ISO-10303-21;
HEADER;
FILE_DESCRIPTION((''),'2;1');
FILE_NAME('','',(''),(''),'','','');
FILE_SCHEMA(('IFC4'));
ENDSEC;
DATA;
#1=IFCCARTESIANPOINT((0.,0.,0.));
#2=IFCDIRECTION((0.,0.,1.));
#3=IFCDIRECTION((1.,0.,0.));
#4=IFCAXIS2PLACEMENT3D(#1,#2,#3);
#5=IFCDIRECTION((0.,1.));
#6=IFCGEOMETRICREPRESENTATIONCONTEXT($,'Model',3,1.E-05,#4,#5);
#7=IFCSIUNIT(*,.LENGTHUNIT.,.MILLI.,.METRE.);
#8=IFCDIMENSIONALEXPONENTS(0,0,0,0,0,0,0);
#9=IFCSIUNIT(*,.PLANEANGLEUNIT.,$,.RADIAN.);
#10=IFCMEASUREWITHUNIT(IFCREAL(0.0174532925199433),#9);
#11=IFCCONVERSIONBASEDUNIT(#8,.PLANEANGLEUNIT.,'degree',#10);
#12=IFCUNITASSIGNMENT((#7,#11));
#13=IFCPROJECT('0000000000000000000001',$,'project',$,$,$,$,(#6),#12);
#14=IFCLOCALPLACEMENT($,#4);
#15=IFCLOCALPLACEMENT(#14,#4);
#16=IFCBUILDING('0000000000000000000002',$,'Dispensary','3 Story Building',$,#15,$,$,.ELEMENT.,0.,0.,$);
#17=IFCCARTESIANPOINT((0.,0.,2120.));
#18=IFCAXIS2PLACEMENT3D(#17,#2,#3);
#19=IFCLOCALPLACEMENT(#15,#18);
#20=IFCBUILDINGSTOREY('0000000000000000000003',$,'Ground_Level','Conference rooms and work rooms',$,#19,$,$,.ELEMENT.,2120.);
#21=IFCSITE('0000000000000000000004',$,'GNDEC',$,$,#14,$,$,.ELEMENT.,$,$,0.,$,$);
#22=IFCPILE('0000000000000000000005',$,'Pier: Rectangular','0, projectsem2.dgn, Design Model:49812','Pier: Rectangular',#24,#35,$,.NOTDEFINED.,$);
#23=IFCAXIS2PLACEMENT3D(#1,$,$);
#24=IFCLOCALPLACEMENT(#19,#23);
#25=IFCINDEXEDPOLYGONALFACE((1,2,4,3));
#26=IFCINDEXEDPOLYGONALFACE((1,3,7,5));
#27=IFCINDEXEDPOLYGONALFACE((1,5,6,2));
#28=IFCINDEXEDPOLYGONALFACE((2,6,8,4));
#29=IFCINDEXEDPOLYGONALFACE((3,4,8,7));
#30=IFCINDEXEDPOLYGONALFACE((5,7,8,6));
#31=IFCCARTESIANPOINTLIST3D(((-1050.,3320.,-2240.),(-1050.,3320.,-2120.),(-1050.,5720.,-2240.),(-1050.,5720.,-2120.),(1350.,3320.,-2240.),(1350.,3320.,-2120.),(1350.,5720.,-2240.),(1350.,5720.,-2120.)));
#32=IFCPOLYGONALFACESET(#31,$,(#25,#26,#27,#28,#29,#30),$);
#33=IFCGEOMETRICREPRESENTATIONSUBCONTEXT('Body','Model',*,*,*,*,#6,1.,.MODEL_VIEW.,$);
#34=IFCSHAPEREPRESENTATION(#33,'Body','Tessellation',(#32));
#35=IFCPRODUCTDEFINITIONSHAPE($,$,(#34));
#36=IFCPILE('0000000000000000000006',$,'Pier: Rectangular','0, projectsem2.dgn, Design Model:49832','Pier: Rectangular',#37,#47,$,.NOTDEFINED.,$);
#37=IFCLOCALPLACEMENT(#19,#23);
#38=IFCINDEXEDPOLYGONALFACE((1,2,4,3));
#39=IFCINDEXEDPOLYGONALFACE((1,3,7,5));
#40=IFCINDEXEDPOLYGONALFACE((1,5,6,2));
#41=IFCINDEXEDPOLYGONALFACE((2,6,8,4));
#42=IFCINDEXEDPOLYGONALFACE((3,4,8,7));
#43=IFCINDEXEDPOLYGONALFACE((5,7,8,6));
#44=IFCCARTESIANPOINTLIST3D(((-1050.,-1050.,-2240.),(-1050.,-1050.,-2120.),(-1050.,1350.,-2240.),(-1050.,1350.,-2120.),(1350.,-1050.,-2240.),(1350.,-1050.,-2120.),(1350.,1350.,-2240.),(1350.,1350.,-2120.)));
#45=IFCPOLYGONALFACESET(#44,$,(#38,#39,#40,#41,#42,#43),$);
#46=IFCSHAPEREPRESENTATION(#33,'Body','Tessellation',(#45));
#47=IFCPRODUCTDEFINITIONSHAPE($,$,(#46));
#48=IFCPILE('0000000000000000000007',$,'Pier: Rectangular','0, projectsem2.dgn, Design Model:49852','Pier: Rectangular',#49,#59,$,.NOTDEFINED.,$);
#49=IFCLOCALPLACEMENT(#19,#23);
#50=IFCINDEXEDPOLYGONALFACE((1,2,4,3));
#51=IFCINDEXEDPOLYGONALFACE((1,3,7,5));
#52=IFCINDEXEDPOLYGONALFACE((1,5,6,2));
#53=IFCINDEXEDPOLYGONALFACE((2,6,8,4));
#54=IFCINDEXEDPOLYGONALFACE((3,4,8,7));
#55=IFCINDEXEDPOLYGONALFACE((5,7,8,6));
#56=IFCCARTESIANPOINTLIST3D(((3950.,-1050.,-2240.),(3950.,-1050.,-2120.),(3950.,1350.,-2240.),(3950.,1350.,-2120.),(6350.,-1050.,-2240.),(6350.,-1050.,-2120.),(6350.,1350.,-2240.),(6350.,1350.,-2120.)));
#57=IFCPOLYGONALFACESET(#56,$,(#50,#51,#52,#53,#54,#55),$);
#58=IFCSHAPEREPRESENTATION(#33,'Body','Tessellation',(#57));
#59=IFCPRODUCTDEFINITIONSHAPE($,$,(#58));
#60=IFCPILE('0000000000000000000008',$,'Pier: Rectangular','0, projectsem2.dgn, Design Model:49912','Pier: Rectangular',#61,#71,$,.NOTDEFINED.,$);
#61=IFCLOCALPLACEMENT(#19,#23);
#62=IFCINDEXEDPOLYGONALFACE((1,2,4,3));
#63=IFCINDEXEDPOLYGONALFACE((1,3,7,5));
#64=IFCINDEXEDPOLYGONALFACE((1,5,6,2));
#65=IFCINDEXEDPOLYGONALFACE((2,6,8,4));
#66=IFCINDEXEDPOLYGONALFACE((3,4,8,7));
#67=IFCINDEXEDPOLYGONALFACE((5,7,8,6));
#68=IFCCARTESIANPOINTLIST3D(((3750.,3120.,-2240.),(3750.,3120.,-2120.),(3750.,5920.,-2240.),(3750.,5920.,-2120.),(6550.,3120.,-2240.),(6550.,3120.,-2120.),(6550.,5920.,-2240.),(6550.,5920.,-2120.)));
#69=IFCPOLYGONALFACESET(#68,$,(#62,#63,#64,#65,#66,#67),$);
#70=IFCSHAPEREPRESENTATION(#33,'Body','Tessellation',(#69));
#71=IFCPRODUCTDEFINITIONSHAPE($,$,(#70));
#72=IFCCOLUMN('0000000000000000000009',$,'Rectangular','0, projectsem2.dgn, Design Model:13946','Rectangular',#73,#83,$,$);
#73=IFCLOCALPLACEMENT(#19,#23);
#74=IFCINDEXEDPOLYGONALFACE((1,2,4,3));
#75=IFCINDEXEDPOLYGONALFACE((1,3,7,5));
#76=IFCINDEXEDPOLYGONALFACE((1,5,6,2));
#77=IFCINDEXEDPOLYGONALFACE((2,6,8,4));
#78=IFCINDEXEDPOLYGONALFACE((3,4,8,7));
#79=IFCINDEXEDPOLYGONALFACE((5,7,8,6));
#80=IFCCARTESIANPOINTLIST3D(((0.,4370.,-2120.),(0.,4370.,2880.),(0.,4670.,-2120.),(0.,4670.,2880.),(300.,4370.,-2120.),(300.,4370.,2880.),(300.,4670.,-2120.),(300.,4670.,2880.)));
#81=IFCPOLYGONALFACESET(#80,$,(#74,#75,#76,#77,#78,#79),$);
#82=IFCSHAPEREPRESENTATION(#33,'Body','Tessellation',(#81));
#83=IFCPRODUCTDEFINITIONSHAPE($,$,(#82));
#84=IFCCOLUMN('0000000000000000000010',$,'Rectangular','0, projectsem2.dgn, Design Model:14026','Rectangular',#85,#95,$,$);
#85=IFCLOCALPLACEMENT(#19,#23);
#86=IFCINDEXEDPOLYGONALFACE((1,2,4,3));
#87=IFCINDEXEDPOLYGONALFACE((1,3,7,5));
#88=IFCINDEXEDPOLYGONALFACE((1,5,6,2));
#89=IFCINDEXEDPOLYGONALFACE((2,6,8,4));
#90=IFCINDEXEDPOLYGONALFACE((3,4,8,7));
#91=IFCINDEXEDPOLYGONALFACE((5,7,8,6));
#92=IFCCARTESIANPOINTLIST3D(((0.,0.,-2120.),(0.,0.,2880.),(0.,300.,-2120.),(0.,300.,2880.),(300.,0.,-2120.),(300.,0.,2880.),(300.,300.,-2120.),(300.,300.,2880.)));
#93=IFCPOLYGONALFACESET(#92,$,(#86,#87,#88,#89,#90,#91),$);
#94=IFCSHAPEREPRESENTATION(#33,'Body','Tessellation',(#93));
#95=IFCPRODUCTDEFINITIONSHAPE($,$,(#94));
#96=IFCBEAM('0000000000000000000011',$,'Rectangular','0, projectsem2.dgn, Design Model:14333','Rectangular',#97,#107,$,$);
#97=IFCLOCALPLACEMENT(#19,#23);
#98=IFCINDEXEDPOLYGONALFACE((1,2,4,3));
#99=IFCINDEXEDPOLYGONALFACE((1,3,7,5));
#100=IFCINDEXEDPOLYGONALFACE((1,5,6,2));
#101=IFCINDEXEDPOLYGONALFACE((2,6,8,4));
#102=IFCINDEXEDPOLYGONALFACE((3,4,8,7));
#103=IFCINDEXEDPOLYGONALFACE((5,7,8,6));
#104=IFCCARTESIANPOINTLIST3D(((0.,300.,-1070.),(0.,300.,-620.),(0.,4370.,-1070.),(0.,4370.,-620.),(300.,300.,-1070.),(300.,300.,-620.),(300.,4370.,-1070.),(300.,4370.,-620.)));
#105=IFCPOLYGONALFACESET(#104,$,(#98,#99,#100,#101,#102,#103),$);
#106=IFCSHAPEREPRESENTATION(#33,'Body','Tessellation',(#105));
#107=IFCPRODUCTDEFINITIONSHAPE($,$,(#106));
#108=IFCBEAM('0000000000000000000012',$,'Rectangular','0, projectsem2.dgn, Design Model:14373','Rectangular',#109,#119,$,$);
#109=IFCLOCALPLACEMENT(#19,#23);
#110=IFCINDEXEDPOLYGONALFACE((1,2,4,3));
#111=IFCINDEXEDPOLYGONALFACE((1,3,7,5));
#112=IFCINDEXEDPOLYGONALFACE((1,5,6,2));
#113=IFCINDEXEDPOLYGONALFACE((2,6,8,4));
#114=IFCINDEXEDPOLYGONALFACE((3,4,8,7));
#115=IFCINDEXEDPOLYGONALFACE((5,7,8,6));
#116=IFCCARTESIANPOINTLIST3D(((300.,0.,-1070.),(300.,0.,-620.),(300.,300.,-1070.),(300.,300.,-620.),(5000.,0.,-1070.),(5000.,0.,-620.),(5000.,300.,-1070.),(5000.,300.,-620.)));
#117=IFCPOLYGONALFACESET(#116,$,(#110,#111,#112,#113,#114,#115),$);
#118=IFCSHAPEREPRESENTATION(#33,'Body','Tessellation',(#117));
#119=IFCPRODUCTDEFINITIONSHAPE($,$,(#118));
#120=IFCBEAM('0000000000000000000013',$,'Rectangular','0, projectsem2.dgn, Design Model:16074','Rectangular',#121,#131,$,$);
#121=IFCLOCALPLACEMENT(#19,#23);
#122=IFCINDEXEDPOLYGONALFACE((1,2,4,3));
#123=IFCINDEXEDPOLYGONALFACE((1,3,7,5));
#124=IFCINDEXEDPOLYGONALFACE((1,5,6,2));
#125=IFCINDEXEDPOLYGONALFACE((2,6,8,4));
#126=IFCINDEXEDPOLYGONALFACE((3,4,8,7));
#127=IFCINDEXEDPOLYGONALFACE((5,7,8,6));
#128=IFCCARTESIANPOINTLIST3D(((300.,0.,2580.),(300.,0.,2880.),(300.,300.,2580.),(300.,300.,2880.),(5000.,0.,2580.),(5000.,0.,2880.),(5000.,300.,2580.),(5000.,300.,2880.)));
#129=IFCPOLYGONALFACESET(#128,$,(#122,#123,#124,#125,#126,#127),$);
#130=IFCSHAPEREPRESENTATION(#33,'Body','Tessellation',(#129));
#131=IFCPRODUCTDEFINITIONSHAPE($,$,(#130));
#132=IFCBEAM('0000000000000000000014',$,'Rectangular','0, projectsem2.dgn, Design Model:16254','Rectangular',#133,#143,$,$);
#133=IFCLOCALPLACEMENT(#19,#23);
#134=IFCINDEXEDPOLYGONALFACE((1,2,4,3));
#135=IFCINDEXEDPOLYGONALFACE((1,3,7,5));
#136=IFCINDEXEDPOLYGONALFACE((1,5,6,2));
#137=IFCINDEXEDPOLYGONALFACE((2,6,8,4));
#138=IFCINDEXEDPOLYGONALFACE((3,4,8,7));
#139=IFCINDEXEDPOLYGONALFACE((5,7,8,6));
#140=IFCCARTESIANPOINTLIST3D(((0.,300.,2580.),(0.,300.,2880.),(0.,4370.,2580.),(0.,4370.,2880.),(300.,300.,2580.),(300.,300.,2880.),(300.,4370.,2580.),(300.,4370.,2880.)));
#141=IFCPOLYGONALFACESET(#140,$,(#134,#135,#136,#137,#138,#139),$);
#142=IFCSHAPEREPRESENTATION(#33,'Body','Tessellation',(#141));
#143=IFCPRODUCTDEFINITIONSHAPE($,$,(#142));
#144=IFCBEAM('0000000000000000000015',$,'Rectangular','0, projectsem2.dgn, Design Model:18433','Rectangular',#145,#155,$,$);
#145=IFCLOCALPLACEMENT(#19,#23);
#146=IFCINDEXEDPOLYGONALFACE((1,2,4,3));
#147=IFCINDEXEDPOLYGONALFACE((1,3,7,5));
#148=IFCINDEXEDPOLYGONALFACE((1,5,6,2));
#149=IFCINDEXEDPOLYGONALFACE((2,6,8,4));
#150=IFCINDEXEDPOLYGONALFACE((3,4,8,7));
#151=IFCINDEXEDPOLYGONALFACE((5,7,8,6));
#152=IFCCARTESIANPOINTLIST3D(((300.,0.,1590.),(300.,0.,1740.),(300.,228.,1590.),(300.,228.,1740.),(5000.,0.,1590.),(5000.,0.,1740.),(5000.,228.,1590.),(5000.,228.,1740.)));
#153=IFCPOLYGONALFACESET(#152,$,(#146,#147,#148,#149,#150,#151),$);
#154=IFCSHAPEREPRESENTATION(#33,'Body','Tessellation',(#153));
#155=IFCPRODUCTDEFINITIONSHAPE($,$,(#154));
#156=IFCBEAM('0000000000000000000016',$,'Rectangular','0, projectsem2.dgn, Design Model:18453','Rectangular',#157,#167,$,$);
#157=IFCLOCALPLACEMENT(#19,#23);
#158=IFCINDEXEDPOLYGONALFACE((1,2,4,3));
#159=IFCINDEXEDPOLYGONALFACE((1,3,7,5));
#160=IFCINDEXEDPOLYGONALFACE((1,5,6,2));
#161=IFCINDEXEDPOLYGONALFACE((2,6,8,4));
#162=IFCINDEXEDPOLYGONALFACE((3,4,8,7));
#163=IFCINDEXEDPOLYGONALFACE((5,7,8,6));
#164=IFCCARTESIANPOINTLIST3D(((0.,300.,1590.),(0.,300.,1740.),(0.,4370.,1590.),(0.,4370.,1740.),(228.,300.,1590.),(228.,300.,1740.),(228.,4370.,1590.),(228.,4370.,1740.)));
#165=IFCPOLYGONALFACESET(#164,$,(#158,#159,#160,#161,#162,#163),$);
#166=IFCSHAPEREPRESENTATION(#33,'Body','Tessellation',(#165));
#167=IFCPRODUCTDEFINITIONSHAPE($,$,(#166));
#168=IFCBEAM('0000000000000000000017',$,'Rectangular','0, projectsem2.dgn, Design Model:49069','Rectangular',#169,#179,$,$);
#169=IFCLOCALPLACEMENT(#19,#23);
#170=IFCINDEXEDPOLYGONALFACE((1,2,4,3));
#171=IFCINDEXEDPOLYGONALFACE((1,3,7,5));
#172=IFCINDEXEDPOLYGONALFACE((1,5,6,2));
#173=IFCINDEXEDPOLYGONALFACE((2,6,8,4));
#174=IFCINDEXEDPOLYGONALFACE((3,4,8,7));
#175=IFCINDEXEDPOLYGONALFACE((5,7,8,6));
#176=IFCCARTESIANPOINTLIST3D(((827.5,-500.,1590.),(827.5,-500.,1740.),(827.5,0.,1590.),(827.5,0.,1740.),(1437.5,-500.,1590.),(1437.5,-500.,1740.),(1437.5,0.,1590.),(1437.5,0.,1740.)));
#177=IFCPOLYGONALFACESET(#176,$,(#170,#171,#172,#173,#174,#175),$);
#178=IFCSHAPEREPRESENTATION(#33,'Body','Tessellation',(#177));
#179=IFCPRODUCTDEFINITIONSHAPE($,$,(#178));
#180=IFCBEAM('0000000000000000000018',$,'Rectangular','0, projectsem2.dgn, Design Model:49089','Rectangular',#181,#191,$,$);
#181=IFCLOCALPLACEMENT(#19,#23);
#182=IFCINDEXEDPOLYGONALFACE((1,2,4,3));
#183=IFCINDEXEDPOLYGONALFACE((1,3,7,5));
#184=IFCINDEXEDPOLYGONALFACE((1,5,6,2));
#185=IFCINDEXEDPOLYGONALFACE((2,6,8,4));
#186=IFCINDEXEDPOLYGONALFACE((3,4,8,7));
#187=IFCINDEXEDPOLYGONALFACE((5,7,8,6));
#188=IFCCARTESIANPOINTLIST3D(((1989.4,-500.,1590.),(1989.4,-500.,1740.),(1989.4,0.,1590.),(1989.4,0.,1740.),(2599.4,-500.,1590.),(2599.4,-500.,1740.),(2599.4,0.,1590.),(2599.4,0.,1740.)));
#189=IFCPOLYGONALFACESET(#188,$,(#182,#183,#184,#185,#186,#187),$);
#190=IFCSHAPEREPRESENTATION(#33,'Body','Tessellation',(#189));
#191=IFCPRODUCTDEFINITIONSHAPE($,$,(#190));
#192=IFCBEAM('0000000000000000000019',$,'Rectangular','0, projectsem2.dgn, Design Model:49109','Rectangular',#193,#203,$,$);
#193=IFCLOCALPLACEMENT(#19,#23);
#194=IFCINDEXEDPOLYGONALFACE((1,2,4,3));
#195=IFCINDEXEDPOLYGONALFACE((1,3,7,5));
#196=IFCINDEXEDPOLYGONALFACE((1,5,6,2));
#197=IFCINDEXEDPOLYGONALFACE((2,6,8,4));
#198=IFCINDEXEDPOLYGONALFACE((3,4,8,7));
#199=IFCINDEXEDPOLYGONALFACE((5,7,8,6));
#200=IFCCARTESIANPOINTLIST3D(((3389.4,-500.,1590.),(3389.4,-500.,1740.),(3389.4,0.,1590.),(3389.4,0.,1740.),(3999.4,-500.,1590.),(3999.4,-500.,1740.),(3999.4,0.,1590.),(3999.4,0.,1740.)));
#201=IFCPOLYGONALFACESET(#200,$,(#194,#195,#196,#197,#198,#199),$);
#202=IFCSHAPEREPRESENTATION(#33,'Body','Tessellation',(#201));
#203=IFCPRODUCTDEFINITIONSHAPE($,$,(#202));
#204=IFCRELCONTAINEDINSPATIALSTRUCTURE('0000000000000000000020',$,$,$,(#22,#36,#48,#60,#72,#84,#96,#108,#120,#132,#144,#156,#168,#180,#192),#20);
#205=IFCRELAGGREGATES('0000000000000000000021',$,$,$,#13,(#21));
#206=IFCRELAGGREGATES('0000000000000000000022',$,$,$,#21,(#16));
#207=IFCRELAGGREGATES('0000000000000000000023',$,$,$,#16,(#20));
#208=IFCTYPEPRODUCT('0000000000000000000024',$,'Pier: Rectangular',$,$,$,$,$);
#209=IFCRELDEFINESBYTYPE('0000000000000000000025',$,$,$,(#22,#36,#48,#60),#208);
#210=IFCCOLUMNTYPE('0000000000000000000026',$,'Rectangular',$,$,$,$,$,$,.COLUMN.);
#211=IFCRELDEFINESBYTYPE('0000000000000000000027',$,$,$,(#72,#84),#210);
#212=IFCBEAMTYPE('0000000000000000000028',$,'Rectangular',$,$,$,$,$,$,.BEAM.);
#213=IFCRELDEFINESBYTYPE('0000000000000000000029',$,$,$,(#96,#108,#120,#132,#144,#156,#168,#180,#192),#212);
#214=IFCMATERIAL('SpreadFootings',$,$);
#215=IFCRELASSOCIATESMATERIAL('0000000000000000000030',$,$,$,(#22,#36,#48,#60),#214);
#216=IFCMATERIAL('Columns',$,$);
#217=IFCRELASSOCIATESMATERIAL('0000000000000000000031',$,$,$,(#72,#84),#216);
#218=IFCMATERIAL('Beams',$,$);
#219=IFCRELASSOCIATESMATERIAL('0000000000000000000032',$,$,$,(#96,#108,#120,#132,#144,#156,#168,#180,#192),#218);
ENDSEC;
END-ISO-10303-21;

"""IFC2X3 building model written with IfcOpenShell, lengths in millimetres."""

from ifc_helpers import new_model, entity, si_unit, converted_unit, direction, frame, frame_2d, origin_with_axes, place, context, subcontext, project, spatial, rectangle, extrude, material, type_object, element, save


model = new_model("IFC2X3")

# Units and contexts
model_context = context("Model", 3, precision=1e-05, world=origin_with_axes(), true_north=direction((0.0, 1.0)))
body_context = subcontext(model_context, "Body", "Model", "MODEL_VIEW", scale=1.0)
ifc_project = project(units=[si_unit("LENGTHUNIT", "METRE", prefix="MILLI"), converted_unit("PLANEANGLEUNIT", "degree", entity("IfcReal", 0.0174532925199433), si_unit("PLANEANGLEUNIT", "RADIAN"), dimensions=[0, 0, 0, 0, 0, 0, 0])], contexts=[model_context])

# Site, building, storey
site_placement = place(None, origin_with_axes())
site = spatial("IfcSite", under=ifc_project, at=site_placement, Name="GNDEC", CompositionType="ELEMENT", RefElevation=0.0)
building_placement = place(site_placement, origin_with_axes())
building = spatial("IfcBuilding", under=site, at=building_placement, Name="Dispensary", Description="3 Story Building", CompositionType="ELEMENT", ElevationOfRefHeight=0.0, ElevationOfTerrain=0.0)
storey_placement = place(building_placement, frame((0.0, 0.0, 2120.0), z_axis=(0.0, 0.0, 1.0), x_axis=(1.0, 0.0, 0.0)))
storey = spatial("IfcBuildingStorey", under=building, at=storey_placement, Name="Ground_Level", Description="Conference rooms and work rooms", CompositionType="ELEMENT", Elevation=2120.0)

# Piles
ifc_material_1 = material(Name="SpreadFootings")
type_product = type_object("IfcTypeProduct", Name="Pier: Rectangular")
for number, where, z_axis, x_axis, name, description in (
    (1, (-1050.0, 5720.0, -2240.0), (0.0, 0.0, 1.0), (0.0, -1.0, 0.0), "Pier: Rectangular", "0, projectsem2.dgn, Design Model:49812"),
    (2, (-1050.0, 1350.0, -2240.0), (0.0, 0.0, 1.0), (0.0, -1.0, 0.0), "Pier: Rectangular", "0, projectsem2.dgn, Design Model:49832"),
    (3, (3950.0, 1350.0, -2240.0), (0.0, 0.0, 1.0), (0.0, -1.0, 0.0), "Pier: Rectangular", "0, projectsem2.dgn, Design Model:49852"),
):
    element("IfcPile", number, at=place(storey_placement, frame(where, z_axis=z_axis, x_axis=x_axis)), inside=storey, type_object=type_product, material=ifc_material_1, Name=name, Description=description, ObjectType="Pier: Rectangular", PredefinedType="NOTDEFINED", context=body_context, shape_type="SweptSolid", body=[
        extrude(rectangle(XDim=2400.0, YDim=2400.0, at=frame_2d((1200.0, 1200.0), x_axis=(0.0, 1.0))), origin_with_axes(), (0.0, 0.0, 1.0), 120.0),
    ])
pile_placement = place(storey_placement, frame((3750.0, 5920.0, -2240.0), z_axis=(0.0, 0.0, 1.0), x_axis=(0.0, -1.0, 0.0)))
element("IfcPile", 4, at=pile_placement, inside=storey, type_object=type_product, material=ifc_material_1, Name="Pier: Rectangular", Description="0, projectsem2.dgn, Design Model:49912", ObjectType="Pier: Rectangular", PredefinedType="NOTDEFINED", context=body_context, shape_type="SweptSolid", body=[
    extrude(rectangle(XDim=2800.0, YDim=2800.0, at=frame_2d((1400.0, 1400.0), x_axis=(0.0, 1.0))), origin_with_axes(), (0.0, 0.0, 1.0), 120.0),
])

# Columns
ifc_material_2 = material(Name="Columns")
column_type = type_object("IfcColumnType", Name="Rectangular", PredefinedType="COLUMN")
for number, where, z_axis, x_axis, name, description in (
    (5, (0.0, 4670.0, -2120.0), (0.0, 0.0, 1.0), (0.0, -1.0, 0.0), "Rectangular", "0, projectsem2.dgn, Design Model:13946"),
    (6, (0.0, 300.0, -2120.0), (0.0, 0.0, 1.0), (0.0, -1.0, 0.0), "Rectangular", "0, projectsem2.dgn, Design Model:14026"),
):
    element("IfcColumn", number, at=place(storey_placement, frame(where, z_axis=z_axis, x_axis=x_axis)), inside=storey, type_object=column_type, material=ifc_material_2, Name=name, Description=description, ObjectType="Rectangular", context=body_context, shape_type="SweptSolid", body=[
        extrude(rectangle(XDim=300.0, YDim=300.0, at=frame_2d((150.0, 150.0), x_axis=(0.0, 1.0))), origin_with_axes(), (0.0, 0.0, 1.0), 5000.0),
    ])

# Beams
ifc_material_3 = material(Name="Beams")
beam_type = type_object("IfcBeamType", Name="Rectangular", PredefinedType="BEAM")
beam_1_placement = place(storey_placement, frame((300.0, 4370.0, -1070.0), z_axis=(0.0, -1.0, 0.0), x_axis=(0.0, 0.0, 1.0)))
element("IfcBeam", 7, at=beam_1_placement, inside=storey, type_object=beam_type, material=ifc_material_3, Name="Rectangular", Description="0, projectsem2.dgn, Design Model:14333", ObjectType="Rectangular", context=body_context, shape_type="SweptSolid", body=[
    extrude(rectangle(XDim=300.0, YDim=450.0, at=frame_2d((225.0, 150.0), x_axis=(0.0, 1.0))), origin_with_axes(), (0.0, 0.0, 1.0), 4070.0),
])
beam_2_placement = place(storey_placement, frame((5000.0, 0.0, -1070.0), z_axis=(-1.0, 0.0, 0.0), x_axis=(0.0, 0.0, 1.0)))
element("IfcBeam", 8, at=beam_2_placement, inside=storey, type_object=beam_type, material=ifc_material_3, Name="Rectangular", Description="0, projectsem2.dgn, Design Model:14373", ObjectType="Rectangular", context=body_context, shape_type="SweptSolid", body=[
    extrude(rectangle(XDim=300.0, YDim=450.0, at=frame_2d((225.0, 150.0), x_axis=(0.0, 1.0))), origin_with_axes(), (0.0, 0.0, 1.0), 4700.0),
])
beam_3_placement = place(storey_placement, frame((5000.0, 0.0, 2580.0), z_axis=(-1.0, 0.0, 0.0), x_axis=(0.0, 0.0, 1.0)))
element("IfcBeam", 9, at=beam_3_placement, inside=storey, type_object=beam_type, material=ifc_material_3, Name="Rectangular", Description="0, projectsem2.dgn, Design Model:16074", ObjectType="Rectangular", context=body_context, shape_type="SweptSolid", body=[
    extrude(rectangle(XDim=300.0, YDim=300.0, at=frame_2d((150.0, 150.0), x_axis=(0.0, 1.0))), origin_with_axes(), (0.0, 0.0, 1.0), 4700.0),
])
beam_4_placement = place(storey_placement, frame((0.0, 300.0, 2580.0), z_axis=(0.0, 1.0, 0.0), x_axis=(0.0, 0.0, 1.0)))
element("IfcBeam", 10, at=beam_4_placement, inside=storey, type_object=beam_type, material=ifc_material_3, Name="Rectangular", Description="0, projectsem2.dgn, Design Model:16254", ObjectType="Rectangular", context=body_context, shape_type="SweptSolid", body=[
    extrude(rectangle(XDim=300.0, YDim=300.0, at=frame_2d((150.0, 150.0), x_axis=(0.0, 1.0))), origin_with_axes(), (0.0, 0.0, 1.0), 4070.0),
])
beam_5_placement = place(storey_placement, frame((5000.0, 228.0, 1590.0), z_axis=(-1.0, 0.0, 0.0), x_axis=(0.0, -1.0, 0.0)))
element("IfcBeam", 11, at=beam_5_placement, inside=storey, type_object=beam_type, material=ifc_material_3, Name="Rectangular", Description="0, projectsem2.dgn, Design Model:18433", ObjectType="Rectangular", context=body_context, shape_type="SweptSolid", body=[
    extrude(rectangle(XDim=150.0, YDim=228.0, at=frame_2d((114.0, 75.0), x_axis=(0.0, 1.0))), origin_with_axes(), (0.0, 0.0, 1.0), 4700.0),
])
beam_6_placement = place(storey_placement, frame((228.0, 300.0, 1590.0), z_axis=(0.0, 1.0, 0.0), x_axis=(-1.0, 0.0, 0.0)))
element("IfcBeam", 12, at=beam_6_placement, inside=storey, type_object=beam_type, material=ifc_material_3, Name="Rectangular", Description="0, projectsem2.dgn, Design Model:18453", ObjectType="Rectangular", context=body_context, shape_type="SweptSolid", body=[
    extrude(rectangle(XDim=150.0, YDim=228.0, at=frame_2d((114.0, 75.0), x_axis=(0.0, 1.0))), origin_with_axes(), (0.0, 0.0, 1.0), 4070.0),
])
for number, where, z_axis, x_axis, name, description in (
    (13, (827.5, -500.0, 1590.0), (1.0, 0.0, 0.0), (0.0, 1.0, 0.0), "Rectangular", "0, projectsem2.dgn, Design Model:49069"),
    (14, (1989.4, -500.0, 1590.0), (1.0, 0.0, 0.0), (0.0, 1.0, 0.0), "Rectangular", "0, projectsem2.dgn, Design Model:49089"),
    (15, (3389.4, -500.0, 1590.0), (1.0, 0.0, 0.0), (0.0, 1.0, 0.0), "Rectangular", "0, projectsem2.dgn, Design Model:49109"),
):
    element("IfcBeam", number, at=place(storey_placement, frame(where, z_axis=z_axis, x_axis=x_axis)), inside=storey, type_object=beam_type, material=ifc_material_3, Name=name, Description=description, ObjectType="Rectangular", context=body_context, shape_type="SweptSolid", body=[
        extrude(rectangle(XDim=150.0, YDim=500.0, at=frame_2d((250.0, 75.0), x_axis=(0.0, 1.0))), origin_with_axes(), (0.0, 0.0, 1.0), 610.0),
    ])

save(model, "model.ifc")
